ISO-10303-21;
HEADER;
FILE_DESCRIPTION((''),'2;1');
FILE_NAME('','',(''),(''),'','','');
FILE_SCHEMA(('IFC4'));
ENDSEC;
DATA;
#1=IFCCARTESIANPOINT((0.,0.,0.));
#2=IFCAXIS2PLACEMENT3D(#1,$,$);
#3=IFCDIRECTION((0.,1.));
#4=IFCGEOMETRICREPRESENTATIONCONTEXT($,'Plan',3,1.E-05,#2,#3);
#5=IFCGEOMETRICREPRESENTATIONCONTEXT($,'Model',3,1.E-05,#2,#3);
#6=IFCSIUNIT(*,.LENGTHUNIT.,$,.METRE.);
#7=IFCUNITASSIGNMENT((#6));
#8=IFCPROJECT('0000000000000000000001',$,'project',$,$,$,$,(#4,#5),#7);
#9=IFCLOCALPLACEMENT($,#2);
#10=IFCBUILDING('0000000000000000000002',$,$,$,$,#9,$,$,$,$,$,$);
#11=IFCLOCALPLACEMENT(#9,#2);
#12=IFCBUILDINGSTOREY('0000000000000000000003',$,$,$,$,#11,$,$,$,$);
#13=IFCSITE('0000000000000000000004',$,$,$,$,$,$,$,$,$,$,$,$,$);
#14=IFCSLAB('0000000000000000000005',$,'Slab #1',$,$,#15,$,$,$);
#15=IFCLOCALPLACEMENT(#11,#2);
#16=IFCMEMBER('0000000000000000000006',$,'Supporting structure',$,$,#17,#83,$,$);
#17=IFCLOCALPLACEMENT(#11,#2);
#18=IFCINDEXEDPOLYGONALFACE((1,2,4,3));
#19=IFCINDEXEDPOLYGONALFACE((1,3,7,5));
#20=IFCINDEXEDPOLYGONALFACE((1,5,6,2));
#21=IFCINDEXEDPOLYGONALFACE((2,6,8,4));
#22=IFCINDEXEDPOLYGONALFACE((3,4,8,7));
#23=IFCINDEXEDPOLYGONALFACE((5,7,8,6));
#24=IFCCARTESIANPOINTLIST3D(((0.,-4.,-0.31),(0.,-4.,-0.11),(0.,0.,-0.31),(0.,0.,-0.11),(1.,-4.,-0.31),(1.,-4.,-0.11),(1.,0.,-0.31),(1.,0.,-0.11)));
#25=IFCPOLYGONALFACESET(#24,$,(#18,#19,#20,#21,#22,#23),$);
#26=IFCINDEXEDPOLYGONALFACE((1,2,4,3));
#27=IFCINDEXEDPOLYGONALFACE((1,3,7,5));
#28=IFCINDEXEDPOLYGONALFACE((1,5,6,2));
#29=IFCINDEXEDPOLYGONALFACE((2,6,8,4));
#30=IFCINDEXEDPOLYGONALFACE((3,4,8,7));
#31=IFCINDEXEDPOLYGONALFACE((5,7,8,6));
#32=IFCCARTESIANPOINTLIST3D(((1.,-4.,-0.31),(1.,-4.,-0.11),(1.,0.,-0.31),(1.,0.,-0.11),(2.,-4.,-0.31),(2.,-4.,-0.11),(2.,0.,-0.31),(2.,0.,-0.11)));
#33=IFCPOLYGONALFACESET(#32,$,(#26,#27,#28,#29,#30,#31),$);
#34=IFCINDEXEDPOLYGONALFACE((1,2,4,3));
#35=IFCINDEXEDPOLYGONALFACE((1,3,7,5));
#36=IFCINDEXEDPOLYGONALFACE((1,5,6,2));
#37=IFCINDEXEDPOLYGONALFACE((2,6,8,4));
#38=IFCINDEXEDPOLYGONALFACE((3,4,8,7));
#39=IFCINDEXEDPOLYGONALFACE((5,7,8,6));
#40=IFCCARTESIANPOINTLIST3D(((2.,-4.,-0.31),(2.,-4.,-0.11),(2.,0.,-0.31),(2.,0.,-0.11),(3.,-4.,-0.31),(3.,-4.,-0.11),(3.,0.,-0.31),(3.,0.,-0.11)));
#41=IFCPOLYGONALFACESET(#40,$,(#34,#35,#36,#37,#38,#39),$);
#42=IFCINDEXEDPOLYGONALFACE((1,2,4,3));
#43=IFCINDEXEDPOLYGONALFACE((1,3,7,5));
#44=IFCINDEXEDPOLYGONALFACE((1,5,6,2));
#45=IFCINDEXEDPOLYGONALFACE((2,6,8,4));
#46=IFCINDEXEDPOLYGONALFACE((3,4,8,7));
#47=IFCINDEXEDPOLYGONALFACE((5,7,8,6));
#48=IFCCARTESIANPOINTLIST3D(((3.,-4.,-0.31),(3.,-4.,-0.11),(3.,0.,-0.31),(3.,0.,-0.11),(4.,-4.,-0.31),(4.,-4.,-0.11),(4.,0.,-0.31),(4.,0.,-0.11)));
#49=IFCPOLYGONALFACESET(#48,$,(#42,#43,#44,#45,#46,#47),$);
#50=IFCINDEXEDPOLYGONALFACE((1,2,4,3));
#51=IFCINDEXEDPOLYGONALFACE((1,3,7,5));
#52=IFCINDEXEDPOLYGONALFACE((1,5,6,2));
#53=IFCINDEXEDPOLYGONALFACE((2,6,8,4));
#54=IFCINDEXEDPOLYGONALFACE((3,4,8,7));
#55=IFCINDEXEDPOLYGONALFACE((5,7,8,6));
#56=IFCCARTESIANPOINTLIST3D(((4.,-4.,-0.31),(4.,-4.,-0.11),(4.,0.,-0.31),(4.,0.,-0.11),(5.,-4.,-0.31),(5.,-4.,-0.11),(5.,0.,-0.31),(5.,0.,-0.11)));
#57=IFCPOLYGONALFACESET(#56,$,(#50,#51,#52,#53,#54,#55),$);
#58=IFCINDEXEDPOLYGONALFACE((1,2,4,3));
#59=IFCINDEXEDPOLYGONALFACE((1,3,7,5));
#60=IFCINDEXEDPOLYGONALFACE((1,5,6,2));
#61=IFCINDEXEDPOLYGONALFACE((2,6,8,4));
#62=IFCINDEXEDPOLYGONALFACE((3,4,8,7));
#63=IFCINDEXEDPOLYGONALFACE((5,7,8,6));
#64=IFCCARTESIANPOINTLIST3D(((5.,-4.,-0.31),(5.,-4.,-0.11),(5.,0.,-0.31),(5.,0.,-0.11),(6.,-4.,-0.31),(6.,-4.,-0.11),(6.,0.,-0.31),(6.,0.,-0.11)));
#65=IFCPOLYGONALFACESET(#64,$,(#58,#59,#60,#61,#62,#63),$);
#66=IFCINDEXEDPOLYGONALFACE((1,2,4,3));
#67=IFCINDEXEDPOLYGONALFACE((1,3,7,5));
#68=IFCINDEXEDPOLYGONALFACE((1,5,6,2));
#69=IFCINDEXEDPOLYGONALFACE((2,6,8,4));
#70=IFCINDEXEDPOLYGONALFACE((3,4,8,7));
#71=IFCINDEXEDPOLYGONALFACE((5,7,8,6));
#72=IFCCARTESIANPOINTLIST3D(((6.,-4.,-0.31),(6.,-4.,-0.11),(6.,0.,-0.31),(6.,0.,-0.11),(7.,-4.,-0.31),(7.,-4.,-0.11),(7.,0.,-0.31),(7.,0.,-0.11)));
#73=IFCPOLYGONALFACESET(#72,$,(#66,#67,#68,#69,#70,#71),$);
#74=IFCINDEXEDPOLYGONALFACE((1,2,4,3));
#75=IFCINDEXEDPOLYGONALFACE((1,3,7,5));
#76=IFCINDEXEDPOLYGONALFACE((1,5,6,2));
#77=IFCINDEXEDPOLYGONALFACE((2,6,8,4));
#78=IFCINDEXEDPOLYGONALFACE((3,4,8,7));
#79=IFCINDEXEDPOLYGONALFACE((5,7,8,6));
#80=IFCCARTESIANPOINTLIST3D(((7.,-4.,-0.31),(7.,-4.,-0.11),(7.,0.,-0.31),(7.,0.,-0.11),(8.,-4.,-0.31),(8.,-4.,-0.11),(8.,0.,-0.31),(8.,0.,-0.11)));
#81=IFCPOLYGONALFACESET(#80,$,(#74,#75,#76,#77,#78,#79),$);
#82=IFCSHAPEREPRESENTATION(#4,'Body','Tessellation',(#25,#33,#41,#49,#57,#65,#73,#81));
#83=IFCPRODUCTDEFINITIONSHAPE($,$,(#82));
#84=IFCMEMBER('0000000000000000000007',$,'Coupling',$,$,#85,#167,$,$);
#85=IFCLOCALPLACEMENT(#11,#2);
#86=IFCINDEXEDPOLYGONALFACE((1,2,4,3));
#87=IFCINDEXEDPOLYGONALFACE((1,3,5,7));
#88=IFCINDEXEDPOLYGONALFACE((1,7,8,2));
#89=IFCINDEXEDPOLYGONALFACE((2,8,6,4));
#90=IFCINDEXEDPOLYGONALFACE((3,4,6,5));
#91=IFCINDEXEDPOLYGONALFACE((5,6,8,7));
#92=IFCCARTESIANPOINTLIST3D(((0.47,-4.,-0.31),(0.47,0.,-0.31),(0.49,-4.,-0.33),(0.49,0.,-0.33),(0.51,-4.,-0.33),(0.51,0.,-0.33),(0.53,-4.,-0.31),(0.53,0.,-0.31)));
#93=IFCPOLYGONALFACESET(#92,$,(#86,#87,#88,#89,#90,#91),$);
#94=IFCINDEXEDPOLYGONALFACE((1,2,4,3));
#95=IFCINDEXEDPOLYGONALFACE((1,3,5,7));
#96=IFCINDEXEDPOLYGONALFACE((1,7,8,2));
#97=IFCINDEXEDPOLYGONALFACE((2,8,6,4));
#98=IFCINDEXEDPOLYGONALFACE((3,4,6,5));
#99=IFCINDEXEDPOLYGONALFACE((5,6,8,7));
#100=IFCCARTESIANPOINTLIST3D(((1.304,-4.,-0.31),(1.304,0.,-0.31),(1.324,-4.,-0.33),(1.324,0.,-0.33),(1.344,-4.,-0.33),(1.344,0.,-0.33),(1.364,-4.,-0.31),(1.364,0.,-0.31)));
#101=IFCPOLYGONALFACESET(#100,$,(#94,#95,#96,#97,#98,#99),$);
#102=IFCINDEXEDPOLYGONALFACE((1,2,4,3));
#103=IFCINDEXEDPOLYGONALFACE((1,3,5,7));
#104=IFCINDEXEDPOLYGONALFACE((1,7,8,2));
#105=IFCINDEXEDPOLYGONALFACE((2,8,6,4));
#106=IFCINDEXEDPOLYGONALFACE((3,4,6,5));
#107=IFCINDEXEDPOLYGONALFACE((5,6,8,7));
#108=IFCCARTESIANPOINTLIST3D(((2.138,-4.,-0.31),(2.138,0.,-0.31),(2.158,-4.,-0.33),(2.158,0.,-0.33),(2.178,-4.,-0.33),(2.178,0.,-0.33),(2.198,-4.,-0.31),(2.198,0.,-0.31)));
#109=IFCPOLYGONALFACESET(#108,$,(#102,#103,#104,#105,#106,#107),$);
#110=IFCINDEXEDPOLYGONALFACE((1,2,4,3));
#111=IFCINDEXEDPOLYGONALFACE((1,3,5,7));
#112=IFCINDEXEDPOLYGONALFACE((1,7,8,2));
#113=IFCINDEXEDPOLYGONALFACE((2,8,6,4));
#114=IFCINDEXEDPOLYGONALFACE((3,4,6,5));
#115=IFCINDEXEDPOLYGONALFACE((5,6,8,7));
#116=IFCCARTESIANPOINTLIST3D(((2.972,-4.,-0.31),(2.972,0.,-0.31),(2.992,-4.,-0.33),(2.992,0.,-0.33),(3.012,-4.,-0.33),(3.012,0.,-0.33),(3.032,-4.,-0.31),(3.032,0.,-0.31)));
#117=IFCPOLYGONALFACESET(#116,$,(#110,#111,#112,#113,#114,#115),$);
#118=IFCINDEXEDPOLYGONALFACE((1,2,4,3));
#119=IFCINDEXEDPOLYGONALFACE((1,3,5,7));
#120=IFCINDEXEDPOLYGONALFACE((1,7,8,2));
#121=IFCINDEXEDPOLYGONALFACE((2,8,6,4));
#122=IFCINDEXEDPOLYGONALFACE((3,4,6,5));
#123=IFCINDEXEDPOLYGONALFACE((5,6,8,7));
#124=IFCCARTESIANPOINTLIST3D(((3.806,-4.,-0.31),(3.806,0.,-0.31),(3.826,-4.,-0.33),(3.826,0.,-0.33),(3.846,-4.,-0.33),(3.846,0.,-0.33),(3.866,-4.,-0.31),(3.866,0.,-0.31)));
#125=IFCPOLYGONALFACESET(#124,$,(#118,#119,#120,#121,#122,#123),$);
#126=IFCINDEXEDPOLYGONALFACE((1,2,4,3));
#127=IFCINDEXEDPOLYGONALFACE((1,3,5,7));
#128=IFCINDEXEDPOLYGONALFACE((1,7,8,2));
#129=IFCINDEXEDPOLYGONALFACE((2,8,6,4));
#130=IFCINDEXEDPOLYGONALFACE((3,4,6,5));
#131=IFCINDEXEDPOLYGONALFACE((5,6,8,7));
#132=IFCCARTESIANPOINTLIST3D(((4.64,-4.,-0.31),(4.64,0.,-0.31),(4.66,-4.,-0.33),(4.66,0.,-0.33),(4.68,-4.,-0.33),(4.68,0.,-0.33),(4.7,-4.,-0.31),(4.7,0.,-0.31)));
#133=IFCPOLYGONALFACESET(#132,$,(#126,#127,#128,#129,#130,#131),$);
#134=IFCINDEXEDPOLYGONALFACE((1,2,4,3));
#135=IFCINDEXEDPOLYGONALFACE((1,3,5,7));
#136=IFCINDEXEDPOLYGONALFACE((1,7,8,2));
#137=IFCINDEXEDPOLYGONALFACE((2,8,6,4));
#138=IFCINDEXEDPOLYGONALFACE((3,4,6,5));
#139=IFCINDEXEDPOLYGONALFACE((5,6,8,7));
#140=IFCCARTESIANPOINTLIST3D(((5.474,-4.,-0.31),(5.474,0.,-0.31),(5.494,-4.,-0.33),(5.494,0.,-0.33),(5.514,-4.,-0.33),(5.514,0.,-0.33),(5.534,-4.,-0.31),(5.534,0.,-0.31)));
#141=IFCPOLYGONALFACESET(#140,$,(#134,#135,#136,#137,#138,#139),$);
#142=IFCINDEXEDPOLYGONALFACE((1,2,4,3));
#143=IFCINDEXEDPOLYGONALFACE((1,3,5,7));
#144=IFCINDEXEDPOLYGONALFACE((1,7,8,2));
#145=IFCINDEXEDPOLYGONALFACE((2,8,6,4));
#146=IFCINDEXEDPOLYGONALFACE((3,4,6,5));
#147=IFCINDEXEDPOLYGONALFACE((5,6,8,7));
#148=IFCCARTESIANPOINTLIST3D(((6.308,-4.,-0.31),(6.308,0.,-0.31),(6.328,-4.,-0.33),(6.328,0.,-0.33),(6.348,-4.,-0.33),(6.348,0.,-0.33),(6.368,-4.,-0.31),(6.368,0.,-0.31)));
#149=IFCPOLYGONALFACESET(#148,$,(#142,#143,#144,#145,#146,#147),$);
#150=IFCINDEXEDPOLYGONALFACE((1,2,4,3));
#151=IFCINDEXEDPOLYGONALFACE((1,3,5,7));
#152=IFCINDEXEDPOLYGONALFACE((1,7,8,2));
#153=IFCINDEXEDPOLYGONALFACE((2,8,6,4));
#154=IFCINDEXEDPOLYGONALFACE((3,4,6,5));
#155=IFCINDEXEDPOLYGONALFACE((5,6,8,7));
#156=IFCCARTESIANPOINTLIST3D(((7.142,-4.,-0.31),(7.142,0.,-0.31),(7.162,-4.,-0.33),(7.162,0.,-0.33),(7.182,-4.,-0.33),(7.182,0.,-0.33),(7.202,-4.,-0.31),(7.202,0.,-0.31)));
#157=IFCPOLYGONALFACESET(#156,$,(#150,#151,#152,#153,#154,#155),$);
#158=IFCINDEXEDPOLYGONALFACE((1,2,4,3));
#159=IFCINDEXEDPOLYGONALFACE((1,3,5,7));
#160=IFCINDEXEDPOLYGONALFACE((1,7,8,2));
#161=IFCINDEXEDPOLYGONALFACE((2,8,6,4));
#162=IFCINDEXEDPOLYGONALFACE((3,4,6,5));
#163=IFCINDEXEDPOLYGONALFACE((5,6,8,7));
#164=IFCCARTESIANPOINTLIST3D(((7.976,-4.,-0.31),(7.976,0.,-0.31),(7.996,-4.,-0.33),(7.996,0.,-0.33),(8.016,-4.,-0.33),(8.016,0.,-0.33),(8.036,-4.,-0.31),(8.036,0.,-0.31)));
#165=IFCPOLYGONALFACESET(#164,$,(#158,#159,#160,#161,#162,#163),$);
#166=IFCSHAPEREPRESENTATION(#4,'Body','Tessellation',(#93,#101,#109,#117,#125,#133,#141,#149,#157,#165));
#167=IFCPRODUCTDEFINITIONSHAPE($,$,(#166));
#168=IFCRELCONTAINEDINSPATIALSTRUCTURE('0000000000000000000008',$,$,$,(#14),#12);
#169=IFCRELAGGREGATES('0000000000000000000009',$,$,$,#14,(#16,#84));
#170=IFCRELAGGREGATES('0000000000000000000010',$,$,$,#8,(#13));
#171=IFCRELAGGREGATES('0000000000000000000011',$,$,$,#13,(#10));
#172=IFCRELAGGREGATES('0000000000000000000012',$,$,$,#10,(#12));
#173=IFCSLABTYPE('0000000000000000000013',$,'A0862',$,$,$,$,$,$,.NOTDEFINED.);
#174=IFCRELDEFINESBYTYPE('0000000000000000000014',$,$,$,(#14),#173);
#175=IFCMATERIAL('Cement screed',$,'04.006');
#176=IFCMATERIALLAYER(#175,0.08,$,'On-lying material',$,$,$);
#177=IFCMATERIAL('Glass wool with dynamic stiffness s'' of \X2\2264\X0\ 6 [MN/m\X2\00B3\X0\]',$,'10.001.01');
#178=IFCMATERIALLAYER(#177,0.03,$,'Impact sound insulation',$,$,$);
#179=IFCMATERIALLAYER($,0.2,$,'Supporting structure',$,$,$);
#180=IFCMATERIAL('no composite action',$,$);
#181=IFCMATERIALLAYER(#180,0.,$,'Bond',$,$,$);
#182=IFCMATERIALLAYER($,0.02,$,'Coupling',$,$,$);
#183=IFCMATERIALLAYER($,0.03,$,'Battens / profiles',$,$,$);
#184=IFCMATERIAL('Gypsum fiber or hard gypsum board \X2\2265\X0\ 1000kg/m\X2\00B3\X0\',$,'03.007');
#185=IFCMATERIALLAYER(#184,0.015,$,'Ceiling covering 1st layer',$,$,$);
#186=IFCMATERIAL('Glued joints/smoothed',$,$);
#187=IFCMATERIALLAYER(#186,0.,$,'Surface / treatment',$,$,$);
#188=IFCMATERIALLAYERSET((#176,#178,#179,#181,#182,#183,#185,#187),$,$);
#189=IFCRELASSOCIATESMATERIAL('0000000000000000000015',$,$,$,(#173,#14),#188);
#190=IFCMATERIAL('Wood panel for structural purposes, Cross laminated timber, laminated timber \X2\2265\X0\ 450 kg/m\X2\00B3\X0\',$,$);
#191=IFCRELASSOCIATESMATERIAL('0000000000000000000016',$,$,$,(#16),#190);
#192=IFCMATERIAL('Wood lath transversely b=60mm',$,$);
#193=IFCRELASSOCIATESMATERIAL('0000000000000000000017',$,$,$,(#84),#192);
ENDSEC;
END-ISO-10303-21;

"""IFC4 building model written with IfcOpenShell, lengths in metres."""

from ifc_helpers import new_model, si_unit, direction, frame, frame_2d, origin, place, context, project, spatial, polyline, rectangle, outline, extrude, material, layer, layer_set, type_object, element, aggregate, save


model = new_model("IFC4")

# Units and contexts
plan_context = context("Plan", 3, precision=1e-05, world=origin(), true_north=direction((0.0, 1.0)))
model_context = context("Model", 3, precision=1e-05, world=origin(), true_north=direction((0.0, 1.0)))
ifc_project = project(units=[si_unit("LENGTHUNIT", "METRE")], contexts=[plan_context, model_context])

# Site, building, storey
site = spatial("IfcSite", under=ifc_project)
building_placement = place(None, origin())
building = spatial("IfcBuilding", under=site, at=building_placement)
storey_placement = place(building_placement, origin())
storey = spatial("IfcBuildingStorey", under=building, at=storey_placement)

# Slab, members
ifc_material_1 = material(Name="Cement screed", Category="04.006")
ifc_layer_1 = layer(ifc_material_1, 0.08, Name="On-lying material")
ifc_material_2 = material(Name="Glass wool with dynamic stiffness s' of ≤ 6 [MN/m³]", Category="10.001.01")
ifc_layer_2 = layer(ifc_material_2, 0.03, Name="Impact sound insulation")
ifc_layer_3 = layer(None, 0.2, Name="Supporting structure")
ifc_material_3 = material(Name="no composite action")
ifc_layer_4 = layer(ifc_material_3, 0.0, Name="Bond")
ifc_layer_5 = layer(None, 0.02, Name="Coupling")
ifc_layer_6 = layer(None, 0.03, Name="Battens / profiles")
ifc_material_4 = material(Name="Gypsum fiber or hard gypsum board ≥ 1000kg/m³", Category="03.007")
ifc_layer_7 = layer(ifc_material_4, 0.015, Name="Ceiling covering 1st layer")
ifc_material_5 = material(Name="Glued joints/smoothed")
ifc_layer_8 = layer(ifc_material_5, 0.0, Name="Surface / treatment")
ifc_layer_set = layer_set([ifc_layer_1, ifc_layer_2, ifc_layer_3, ifc_layer_4, ifc_layer_5, ifc_layer_6, ifc_layer_7, ifc_layer_8])
slab_type = type_object("IfcSlabType", Name="A0862", PredefinedType="NOTDEFINED", material=ifc_layer_set)
slab_placement = place(None, frame((0.0, 0.0, 0.0), z_axis=(0.0, 0.0, -1.0), x_axis=(1.0, 0.0, 0.0)))
slab = element("IfcSlab", 1, at=slab_placement, inside=storey, type_object=slab_type, material=ifc_layer_set, Name="Slab #1")
ifc_material_6 = material(Name="Wood panel for structural purposes, Cross laminated timber, laminated timber ≥ 450 kg/m³")
member_1_placement = place(slab_placement, origin())
member_1 = element("IfcMember", 2, at=member_1_placement, material=ifc_material_6, Name="Supporting structure", context=plan_context, shape_type="SweptSolid", body=[
    extrude(rectangle(XDim=1.0, YDim=0.2, at=frame_2d((0.5, 0.1), x_axis=(1.0, 0.0))), frame((0.0, 4.0, 0.11), z_axis=(0.0, -1.0, 0.0), x_axis=(1.0, 0.0, 0.0)), (0.0, 0.0, 1.0), 4.0),
    extrude(rectangle(XDim=1.0, YDim=0.2, at=frame_2d((0.5, 0.1), x_axis=(1.0, 0.0))), frame((1.0, 4.0, 0.11), z_axis=(0.0, -1.0, 0.0), x_axis=(1.0, 0.0, 0.0)), (0.0, 0.0, 1.0), 4.0),
    extrude(rectangle(XDim=1.0, YDim=0.2, at=frame_2d((0.5, 0.1), x_axis=(1.0, 0.0))), frame((2.0, 4.0, 0.11), z_axis=(0.0, -1.0, 0.0), x_axis=(1.0, 0.0, 0.0)), (0.0, 0.0, 1.0), 4.0),
    extrude(rectangle(XDim=1.0, YDim=0.2, at=frame_2d((0.5, 0.1), x_axis=(1.0, 0.0))), frame((3.0, 4.0, 0.11), z_axis=(0.0, -1.0, 0.0), x_axis=(1.0, 0.0, 0.0)), (0.0, 0.0, 1.0), 4.0),
    extrude(rectangle(XDim=1.0, YDim=0.2, at=frame_2d((0.5, 0.1), x_axis=(1.0, 0.0))), frame((4.0, 4.0, 0.11), z_axis=(0.0, -1.0, 0.0), x_axis=(1.0, 0.0, 0.0)), (0.0, 0.0, 1.0), 4.0),
    extrude(rectangle(XDim=1.0, YDim=0.2, at=frame_2d((0.5, 0.1), x_axis=(1.0, 0.0))), frame((5.0, 4.0, 0.11), z_axis=(0.0, -1.0, 0.0), x_axis=(1.0, 0.0, 0.0)), (0.0, 0.0, 1.0), 4.0),
    extrude(rectangle(XDim=1.0, YDim=0.2, at=frame_2d((0.5, 0.1), x_axis=(1.0, 0.0))), frame((6.0, 4.0, 0.11), z_axis=(0.0, -1.0, 0.0), x_axis=(1.0, 0.0, 0.0)), (0.0, 0.0, 1.0), 4.0),
    extrude(rectangle(XDim=1.0, YDim=0.2, at=frame_2d((0.5, 0.1), x_axis=(1.0, 0.0))), frame((7.0, 4.0, 0.11), z_axis=(0.0, -1.0, 0.0), x_axis=(1.0, 0.0, 0.0)), (0.0, 0.0, 1.0), 4.0),
])
ifc_material_7 = material(Name="Wood lath transversely b=60mm")
member_2_placement = place(slab_placement, origin())
member_2 = element("IfcMember", 3, at=member_2_placement, material=ifc_material_7, Name="Coupling", context=plan_context, shape_type="SweptSolid", body=[
    extrude(outline(polyline([(0.0, 0.0), (0.06, 0.0), (0.04, 0.02), (0.02, 0.02), (0.0, 0.0)])), frame((0.47, 4.0, 0.31), z_axis=(0.0, -1.0, 0.0), x_axis=(1.0, 0.0, 0.0)), (0.0, 0.0, 1.0), 4.0),
    extrude(outline(polyline([(0.0, 0.0), (0.06, 0.0), (0.04, 0.02), (0.02, 0.02), (0.0, 0.0)])), frame((1.304, 4.0, 0.31), z_axis=(0.0, -1.0, 0.0), x_axis=(1.0, 0.0, 0.0)), (0.0, 0.0, 1.0), 4.0),
    extrude(outline(polyline([(0.0, 0.0), (0.06, 0.0), (0.04, 0.02), (0.02, 0.02), (0.0, 0.0)])), frame((2.138, 4.0, 0.31), z_axis=(0.0, -1.0, 0.0), x_axis=(1.0, 0.0, 0.0)), (0.0, 0.0, 1.0), 4.0),
    extrude(outline(polyline([(0.0, 0.0), (0.06, 0.0), (0.04, 0.02), (0.02, 0.02), (0.0, 0.0)])), frame((2.972, 4.0, 0.31), z_axis=(0.0, -1.0, 0.0), x_axis=(1.0, 0.0, 0.0)), (0.0, 0.0, 1.0), 4.0),
    extrude(outline(polyline([(0.0, 0.0), (0.06, 0.0), (0.04, 0.02), (0.02, 0.02), (0.0, 0.0)])), frame((3.806, 4.0, 0.31), z_axis=(0.0, -1.0, 0.0), x_axis=(1.0, 0.0, 0.0)), (0.0, 0.0, 1.0), 4.0),
    extrude(outline(polyline([(0.0, 0.0), (0.06, 0.0), (0.04, 0.02), (0.02, 0.02), (0.0, 0.0)])), frame((4.64, 4.0, 0.31), z_axis=(0.0, -1.0, 0.0), x_axis=(1.0, 0.0, 0.0)), (0.0, 0.0, 1.0), 4.0),
    extrude(outline(polyline([(0.0, 0.0), (0.06, 0.0), (0.04, 0.02), (0.02, 0.02), (0.0, 0.0)])), frame((5.474, 4.0, 0.31), z_axis=(0.0, -1.0, 0.0), x_axis=(1.0, 0.0, 0.0)), (0.0, 0.0, 1.0), 4.0),
    extrude(outline(polyline([(0.0, 0.0), (0.06, 0.0), (0.04, 0.02), (0.02, 0.02), (0.0, 0.0)])), frame((6.308, 4.0, 0.31), z_axis=(0.0, -1.0, 0.0), x_axis=(1.0, 0.0, 0.0)), (0.0, 0.0, 1.0), 4.0),
    extrude(outline(polyline([(0.0, 0.0), (0.06, 0.0), (0.04, 0.02), (0.02, 0.02), (0.0, 0.0)])), frame((7.142, 4.0, 0.31), z_axis=(0.0, -1.0, 0.0), x_axis=(1.0, 0.0, 0.0)), (0.0, 0.0, 1.0), 4.0),
    extrude(outline(polyline([(0.0, 0.0), (0.06, 0.0), (0.04, 0.02), (0.02, 0.02), (0.0, 0.0)])), frame((7.976, 4.0, 0.31), z_axis=(0.0, -1.0, 0.0), x_axis=(1.0, 0.0, 0.0)), (0.0, 0.0, 1.0), 4.0),
])
aggregate(slab, [member_1, member_2])

save(model, "model.ifc")
